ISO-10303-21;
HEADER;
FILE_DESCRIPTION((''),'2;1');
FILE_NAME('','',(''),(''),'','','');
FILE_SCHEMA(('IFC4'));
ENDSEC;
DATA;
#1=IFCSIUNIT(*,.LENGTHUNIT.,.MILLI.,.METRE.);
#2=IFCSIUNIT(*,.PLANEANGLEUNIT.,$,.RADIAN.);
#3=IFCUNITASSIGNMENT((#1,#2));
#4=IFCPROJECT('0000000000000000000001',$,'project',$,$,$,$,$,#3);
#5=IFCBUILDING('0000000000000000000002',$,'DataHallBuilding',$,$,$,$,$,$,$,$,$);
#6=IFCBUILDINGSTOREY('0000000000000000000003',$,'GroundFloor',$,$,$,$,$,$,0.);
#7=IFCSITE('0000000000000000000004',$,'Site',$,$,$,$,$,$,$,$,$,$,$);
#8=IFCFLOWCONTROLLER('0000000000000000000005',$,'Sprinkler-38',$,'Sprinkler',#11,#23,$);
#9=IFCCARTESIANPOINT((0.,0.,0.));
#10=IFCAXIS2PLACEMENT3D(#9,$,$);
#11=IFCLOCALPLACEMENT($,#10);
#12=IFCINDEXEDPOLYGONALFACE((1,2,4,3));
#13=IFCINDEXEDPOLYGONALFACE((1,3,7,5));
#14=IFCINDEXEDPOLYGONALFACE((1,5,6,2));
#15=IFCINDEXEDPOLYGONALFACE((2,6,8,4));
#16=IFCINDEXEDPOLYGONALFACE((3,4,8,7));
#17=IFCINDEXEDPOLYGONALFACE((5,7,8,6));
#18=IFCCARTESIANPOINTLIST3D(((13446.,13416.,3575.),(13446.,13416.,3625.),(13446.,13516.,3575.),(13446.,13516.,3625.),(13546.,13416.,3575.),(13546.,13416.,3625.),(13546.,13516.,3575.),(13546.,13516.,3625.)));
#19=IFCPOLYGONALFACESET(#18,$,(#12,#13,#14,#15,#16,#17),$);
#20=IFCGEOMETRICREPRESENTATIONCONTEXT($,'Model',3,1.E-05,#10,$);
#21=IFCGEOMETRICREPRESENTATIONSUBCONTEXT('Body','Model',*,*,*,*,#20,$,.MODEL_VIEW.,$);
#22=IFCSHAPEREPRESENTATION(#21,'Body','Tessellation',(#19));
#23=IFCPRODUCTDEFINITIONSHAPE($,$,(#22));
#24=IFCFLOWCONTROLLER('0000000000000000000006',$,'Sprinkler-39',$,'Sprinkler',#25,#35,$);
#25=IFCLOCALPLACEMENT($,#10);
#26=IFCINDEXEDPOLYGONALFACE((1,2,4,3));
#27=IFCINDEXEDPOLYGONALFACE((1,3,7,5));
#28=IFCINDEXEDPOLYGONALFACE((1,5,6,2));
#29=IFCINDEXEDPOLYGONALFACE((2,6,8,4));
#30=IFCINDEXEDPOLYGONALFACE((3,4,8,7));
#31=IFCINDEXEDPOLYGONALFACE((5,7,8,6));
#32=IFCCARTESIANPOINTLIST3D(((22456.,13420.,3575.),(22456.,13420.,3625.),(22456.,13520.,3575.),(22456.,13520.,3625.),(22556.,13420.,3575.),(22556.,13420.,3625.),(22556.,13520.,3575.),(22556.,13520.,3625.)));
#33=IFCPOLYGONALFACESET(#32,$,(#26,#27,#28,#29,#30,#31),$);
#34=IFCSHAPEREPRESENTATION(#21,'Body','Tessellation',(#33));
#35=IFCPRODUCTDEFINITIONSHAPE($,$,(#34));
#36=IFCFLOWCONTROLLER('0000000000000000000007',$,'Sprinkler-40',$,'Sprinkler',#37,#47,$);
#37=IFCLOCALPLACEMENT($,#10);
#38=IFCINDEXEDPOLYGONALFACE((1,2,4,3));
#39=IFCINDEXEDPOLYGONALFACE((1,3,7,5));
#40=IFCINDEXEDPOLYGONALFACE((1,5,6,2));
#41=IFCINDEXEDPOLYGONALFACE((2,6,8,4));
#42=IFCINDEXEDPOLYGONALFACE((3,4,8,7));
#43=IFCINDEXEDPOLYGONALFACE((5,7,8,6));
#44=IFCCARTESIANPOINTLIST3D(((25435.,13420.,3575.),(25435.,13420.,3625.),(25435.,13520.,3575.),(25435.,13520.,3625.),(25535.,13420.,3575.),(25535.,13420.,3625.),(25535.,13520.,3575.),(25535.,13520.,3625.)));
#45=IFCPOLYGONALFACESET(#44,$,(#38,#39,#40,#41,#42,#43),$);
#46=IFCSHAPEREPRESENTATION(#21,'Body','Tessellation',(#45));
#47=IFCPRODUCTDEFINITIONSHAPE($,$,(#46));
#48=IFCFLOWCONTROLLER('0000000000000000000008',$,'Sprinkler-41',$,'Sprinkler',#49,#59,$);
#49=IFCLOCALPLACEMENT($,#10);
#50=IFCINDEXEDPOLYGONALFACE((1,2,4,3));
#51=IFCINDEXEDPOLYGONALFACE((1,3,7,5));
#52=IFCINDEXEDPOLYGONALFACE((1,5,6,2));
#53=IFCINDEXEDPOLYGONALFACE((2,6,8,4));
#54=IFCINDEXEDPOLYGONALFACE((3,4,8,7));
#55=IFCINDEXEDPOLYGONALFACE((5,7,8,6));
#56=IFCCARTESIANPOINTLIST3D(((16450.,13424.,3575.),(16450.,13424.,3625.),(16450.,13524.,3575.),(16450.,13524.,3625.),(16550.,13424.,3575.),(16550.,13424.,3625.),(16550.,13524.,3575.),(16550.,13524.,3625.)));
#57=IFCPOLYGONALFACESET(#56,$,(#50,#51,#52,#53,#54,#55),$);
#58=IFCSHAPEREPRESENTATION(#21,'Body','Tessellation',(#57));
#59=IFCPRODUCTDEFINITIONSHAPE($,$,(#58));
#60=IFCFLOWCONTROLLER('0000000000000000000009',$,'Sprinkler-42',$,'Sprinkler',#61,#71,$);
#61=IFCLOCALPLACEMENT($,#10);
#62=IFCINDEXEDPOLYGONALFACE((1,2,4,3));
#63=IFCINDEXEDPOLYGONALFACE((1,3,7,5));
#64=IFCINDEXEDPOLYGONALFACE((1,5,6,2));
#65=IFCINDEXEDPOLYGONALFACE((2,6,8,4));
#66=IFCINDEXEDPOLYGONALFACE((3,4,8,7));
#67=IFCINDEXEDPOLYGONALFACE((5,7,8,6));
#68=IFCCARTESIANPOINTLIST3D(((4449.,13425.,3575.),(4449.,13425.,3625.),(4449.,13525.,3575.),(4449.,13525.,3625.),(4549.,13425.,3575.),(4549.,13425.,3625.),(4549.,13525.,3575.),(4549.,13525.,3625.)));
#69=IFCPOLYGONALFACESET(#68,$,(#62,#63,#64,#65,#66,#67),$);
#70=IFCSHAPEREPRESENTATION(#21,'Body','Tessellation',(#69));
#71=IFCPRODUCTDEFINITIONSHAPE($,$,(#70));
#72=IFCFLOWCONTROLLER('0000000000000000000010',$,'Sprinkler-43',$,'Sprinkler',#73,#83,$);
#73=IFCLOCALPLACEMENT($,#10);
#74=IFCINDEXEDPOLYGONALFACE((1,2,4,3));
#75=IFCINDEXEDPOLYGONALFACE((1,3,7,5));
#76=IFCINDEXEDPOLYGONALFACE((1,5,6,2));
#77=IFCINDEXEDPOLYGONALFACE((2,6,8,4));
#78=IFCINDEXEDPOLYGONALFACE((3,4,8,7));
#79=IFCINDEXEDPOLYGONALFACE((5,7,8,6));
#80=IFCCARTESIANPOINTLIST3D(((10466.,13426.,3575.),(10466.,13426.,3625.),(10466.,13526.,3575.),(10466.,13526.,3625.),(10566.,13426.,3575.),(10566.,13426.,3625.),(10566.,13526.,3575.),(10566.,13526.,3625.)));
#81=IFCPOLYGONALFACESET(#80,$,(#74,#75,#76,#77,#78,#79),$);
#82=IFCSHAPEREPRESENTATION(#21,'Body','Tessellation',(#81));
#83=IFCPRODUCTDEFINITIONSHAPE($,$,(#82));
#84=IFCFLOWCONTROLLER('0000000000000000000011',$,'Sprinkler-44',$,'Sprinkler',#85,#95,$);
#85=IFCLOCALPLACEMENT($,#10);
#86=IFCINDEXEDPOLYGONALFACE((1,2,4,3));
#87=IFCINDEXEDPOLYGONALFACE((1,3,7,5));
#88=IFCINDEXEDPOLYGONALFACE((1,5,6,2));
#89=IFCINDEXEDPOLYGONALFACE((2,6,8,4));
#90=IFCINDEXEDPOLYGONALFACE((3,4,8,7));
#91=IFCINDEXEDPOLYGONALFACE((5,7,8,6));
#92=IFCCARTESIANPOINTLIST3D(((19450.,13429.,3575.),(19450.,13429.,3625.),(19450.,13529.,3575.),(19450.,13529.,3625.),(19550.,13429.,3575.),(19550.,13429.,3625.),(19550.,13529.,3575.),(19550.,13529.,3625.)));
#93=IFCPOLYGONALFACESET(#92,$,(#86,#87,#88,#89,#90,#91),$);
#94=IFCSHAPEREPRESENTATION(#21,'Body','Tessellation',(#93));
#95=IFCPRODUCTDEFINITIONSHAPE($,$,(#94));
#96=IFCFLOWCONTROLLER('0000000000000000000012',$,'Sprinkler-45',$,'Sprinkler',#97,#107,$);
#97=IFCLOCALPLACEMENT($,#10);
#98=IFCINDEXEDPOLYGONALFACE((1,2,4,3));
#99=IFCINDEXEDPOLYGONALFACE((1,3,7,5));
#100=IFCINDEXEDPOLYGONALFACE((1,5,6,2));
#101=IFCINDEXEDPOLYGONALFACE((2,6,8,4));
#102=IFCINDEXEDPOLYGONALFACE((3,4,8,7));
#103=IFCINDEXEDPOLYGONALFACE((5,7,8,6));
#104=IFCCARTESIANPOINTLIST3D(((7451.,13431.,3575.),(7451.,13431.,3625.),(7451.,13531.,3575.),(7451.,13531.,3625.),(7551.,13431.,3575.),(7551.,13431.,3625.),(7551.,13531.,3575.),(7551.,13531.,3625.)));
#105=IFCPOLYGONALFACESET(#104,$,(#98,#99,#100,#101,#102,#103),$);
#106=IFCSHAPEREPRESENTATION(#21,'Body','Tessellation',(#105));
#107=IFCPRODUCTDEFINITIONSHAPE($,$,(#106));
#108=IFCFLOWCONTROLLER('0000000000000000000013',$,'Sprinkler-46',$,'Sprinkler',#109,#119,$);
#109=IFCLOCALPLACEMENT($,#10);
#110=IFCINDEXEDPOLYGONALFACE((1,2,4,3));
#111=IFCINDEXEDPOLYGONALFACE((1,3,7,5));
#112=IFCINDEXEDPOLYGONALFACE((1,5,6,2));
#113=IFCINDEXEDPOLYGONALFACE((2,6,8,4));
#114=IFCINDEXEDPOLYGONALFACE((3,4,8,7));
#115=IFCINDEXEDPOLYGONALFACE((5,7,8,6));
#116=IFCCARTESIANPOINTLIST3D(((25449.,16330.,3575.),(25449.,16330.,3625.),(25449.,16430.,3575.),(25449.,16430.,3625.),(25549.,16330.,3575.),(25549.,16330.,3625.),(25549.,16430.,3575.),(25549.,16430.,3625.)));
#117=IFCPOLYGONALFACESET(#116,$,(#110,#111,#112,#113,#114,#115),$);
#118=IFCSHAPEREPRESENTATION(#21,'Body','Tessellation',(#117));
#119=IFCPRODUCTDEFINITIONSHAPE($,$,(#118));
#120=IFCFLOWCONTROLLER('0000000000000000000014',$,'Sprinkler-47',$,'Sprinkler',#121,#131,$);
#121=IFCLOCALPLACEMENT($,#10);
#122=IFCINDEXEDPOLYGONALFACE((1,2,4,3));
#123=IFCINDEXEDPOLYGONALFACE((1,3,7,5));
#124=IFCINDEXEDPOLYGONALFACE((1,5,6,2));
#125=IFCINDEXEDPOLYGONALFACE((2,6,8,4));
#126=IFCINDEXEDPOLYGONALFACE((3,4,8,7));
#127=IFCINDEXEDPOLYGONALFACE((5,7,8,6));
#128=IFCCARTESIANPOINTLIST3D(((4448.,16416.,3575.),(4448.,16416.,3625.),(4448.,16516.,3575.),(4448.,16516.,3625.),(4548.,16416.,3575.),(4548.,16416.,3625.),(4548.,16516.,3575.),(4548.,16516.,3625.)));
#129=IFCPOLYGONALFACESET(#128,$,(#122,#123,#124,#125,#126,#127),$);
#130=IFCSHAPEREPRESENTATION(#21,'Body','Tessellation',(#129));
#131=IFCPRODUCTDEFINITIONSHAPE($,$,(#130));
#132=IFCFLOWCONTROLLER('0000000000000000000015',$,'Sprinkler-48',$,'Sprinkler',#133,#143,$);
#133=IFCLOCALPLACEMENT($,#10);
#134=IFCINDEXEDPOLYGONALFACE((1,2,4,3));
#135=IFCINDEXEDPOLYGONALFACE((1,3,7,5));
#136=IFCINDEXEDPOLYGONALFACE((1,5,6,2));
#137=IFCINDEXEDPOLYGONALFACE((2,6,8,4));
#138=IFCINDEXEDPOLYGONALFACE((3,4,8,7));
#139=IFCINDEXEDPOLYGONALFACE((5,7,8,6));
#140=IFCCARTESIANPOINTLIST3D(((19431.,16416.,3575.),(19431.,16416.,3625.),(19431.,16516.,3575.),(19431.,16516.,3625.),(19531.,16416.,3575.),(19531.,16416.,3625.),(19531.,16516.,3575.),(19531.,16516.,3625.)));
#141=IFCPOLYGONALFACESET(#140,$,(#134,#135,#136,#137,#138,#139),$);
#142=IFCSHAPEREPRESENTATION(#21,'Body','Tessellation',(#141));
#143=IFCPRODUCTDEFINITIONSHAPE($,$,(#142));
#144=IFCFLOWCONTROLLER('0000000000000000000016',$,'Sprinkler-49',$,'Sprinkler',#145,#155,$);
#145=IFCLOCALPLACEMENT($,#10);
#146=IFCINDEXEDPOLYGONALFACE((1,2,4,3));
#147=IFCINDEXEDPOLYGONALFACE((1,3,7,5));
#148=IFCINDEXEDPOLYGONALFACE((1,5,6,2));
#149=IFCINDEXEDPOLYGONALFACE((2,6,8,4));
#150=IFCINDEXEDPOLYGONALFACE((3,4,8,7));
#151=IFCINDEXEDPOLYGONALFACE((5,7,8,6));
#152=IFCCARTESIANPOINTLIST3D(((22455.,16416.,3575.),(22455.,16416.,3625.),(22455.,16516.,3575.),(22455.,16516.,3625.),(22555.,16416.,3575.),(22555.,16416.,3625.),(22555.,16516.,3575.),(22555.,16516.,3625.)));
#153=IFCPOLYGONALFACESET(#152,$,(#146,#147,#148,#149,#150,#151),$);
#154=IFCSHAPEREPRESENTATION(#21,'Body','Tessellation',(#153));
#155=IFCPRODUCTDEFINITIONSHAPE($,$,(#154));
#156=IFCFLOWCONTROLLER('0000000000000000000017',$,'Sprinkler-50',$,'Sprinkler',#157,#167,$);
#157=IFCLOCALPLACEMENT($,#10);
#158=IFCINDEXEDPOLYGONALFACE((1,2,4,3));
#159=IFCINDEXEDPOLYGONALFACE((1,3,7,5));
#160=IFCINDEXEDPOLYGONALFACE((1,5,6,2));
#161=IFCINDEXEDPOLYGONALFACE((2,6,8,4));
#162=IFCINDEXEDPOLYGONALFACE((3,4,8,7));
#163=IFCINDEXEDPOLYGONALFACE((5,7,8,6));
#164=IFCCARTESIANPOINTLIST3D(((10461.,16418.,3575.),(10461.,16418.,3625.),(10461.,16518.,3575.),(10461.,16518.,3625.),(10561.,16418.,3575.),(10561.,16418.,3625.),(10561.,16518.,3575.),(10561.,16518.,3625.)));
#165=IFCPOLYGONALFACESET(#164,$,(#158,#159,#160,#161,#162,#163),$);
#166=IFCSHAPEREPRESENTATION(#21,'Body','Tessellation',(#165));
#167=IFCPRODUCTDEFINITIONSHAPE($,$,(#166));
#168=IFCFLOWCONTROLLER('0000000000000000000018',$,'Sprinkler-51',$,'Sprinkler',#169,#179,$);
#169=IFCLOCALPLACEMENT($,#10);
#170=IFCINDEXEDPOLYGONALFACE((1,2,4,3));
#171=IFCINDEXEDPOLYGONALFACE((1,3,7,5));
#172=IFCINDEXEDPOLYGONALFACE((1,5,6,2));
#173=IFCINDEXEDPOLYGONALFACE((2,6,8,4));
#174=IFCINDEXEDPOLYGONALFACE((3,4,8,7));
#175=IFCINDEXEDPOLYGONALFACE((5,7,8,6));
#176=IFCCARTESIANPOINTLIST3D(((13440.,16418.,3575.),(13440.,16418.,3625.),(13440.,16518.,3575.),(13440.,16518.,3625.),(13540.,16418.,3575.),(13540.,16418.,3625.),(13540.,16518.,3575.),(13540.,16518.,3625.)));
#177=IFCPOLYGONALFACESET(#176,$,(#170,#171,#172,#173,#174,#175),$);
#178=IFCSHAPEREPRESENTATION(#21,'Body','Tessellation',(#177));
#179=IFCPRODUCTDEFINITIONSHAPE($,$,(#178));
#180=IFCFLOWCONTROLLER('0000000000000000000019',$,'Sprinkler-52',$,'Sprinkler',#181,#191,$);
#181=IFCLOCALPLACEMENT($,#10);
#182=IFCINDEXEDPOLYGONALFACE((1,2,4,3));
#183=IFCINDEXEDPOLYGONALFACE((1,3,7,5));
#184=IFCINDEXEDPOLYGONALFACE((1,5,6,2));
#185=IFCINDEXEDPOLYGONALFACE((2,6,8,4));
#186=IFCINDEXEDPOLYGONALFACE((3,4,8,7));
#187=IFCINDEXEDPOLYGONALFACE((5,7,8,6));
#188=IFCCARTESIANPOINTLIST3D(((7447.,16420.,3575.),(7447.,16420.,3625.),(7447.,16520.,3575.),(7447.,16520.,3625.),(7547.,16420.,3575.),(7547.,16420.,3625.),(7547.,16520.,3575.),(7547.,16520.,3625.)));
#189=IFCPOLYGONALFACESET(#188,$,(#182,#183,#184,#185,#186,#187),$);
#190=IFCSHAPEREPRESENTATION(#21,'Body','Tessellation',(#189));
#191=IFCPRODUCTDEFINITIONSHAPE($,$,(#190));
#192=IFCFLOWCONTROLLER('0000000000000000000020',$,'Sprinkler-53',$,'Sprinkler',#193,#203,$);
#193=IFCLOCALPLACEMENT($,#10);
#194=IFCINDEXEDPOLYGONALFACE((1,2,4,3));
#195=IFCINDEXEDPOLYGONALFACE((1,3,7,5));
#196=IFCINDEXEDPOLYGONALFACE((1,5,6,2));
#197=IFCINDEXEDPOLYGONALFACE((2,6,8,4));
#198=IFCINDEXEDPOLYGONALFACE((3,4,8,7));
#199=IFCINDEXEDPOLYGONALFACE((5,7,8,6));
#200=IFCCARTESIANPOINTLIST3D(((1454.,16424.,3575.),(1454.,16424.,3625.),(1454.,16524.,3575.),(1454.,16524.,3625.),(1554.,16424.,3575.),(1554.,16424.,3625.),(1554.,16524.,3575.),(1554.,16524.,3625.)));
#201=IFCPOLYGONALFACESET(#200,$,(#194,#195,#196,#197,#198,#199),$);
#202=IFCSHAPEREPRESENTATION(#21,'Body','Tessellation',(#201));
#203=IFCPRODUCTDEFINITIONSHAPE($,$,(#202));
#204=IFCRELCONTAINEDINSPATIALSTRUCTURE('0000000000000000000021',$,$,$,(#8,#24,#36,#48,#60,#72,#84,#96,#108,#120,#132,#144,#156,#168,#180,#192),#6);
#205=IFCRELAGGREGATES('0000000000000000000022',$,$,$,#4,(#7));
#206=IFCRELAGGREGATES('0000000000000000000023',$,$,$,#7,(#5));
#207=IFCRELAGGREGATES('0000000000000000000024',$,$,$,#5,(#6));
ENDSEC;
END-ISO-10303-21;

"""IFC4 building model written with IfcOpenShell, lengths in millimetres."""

from ifc_helpers import new_model, si_unit, frame, origin, place, context, subcontext, project, spatial, rectangle, extrude, element, save


model = new_model("IFC4")

# Units and contexts
model_context = context("Model", 3, precision=1e-05, world=origin())
body_context = subcontext(model_context, "Body", "Model", "MODEL_VIEW")
ifc_project = project(units=[si_unit("LENGTHUNIT", "METRE", prefix="MILLI"), si_unit("PLANEANGLEUNIT", "RADIAN")])

# Site, building, storey
site = spatial("IfcSite", under=ifc_project, Name="Site")
building = spatial("IfcBuilding", under=site, Name="DataHallBuilding")
storey = spatial("IfcBuildingStorey", under=building, Name="GroundFloor", Elevation=0.0)

# Flow controllers
flow_controller_1_placement = place(None, origin())
element("IfcFlowController", 1, at=flow_controller_1_placement, inside=storey, Name="Sprinkler-38", ObjectType="Sprinkler", context=body_context, shape_type="SweptSolid", body=[
    extrude(rectangle(XDim=100.0, YDim=100.0), frame((13496.0, 13466.0, 3575.0), z_axis=(0.0, 0.0, 1.0), x_axis=(1.0, 0.0, 0.0)), (0.0, 0.0, 1.0), 50.0),
])
flow_controller_2_placement = place(None, origin())
element("IfcFlowController", 2, at=flow_controller_2_placement, inside=storey, Name="Sprinkler-39", ObjectType="Sprinkler", context=body_context, shape_type="SweptSolid", body=[
    extrude(rectangle(XDim=100.0, YDim=100.0), frame((22506.0, 13470.0, 3575.0), z_axis=(0.0, 0.0, 1.0), x_axis=(1.0, 0.0, 0.0)), (0.0, 0.0, 1.0), 50.0),
])
flow_controller_3_placement = place(None, origin())
element("IfcFlowController", 3, at=flow_controller_3_placement, inside=storey, Name="Sprinkler-40", ObjectType="Sprinkler", context=body_context, shape_type="SweptSolid", body=[
    extrude(rectangle(XDim=100.0, YDim=100.0), frame((25485.0, 13470.0, 3575.0), z_axis=(0.0, 0.0, 1.0), x_axis=(1.0, 0.0, 0.0)), (0.0, 0.0, 1.0), 50.0),
])
flow_controller_4_placement = place(None, origin())
element("IfcFlowController", 4, at=flow_controller_4_placement, inside=storey, Name="Sprinkler-41", ObjectType="Sprinkler", context=body_context, shape_type="SweptSolid", body=[
    extrude(rectangle(XDim=100.0, YDim=100.0), frame((16500.0, 13474.0, 3575.0), z_axis=(0.0, 0.0, 1.0), x_axis=(1.0, 0.0, 0.0)), (0.0, 0.0, 1.0), 50.0),
])
flow_controller_5_placement = place(None, origin())
element("IfcFlowController", 5, at=flow_controller_5_placement, inside=storey, Name="Sprinkler-42", ObjectType="Sprinkler", context=body_context, shape_type="SweptSolid", body=[
    extrude(rectangle(XDim=100.0, YDim=100.0), frame((4499.0, 13475.0, 3575.0), z_axis=(0.0, 0.0, 1.0), x_axis=(1.0, 0.0, 0.0)), (0.0, 0.0, 1.0), 50.0),
])
flow_controller_6_placement = place(None, origin())
element("IfcFlowController", 6, at=flow_controller_6_placement, inside=storey, Name="Sprinkler-43", ObjectType="Sprinkler", context=body_context, shape_type="SweptSolid", body=[
    extrude(rectangle(XDim=100.0, YDim=100.0), frame((10516.0, 13476.0, 3575.0), z_axis=(0.0, 0.0, 1.0), x_axis=(1.0, 0.0, 0.0)), (0.0, 0.0, 1.0), 50.0),
])
flow_controller_7_placement = place(None, origin())
element("IfcFlowController", 7, at=flow_controller_7_placement, inside=storey, Name="Sprinkler-44", ObjectType="Sprinkler", context=body_context, shape_type="SweptSolid", body=[
    extrude(rectangle(XDim=100.0, YDim=100.0), frame((19500.0, 13479.0, 3575.0), z_axis=(0.0, 0.0, 1.0), x_axis=(1.0, 0.0, 0.0)), (0.0, 0.0, 1.0), 50.0),
])
flow_controller_8_placement = place(None, origin())
element("IfcFlowController", 8, at=flow_controller_8_placement, inside=storey, Name="Sprinkler-45", ObjectType="Sprinkler", context=body_context, shape_type="SweptSolid", body=[
    extrude(rectangle(XDim=100.0, YDim=100.0), frame((7501.0, 13481.0, 3575.0), z_axis=(0.0, 0.0, 1.0), x_axis=(1.0, 0.0, 0.0)), (0.0, 0.0, 1.0), 50.0),
])
flow_controller_9_placement = place(None, origin())
element("IfcFlowController", 9, at=flow_controller_9_placement, inside=storey, Name="Sprinkler-46", ObjectType="Sprinkler", context=body_context, shape_type="SweptSolid", body=[
    extrude(rectangle(XDim=100.0, YDim=100.0), frame((25499.0, 16380.0, 3575.0), z_axis=(0.0, 0.0, 1.0), x_axis=(1.0, 0.0, 0.0)), (0.0, 0.0, 1.0), 50.0),
])
flow_controller_10_placement = place(None, origin())
element("IfcFlowController", 10, at=flow_controller_10_placement, inside=storey, Name="Sprinkler-47", ObjectType="Sprinkler", context=body_context, shape_type="SweptSolid", body=[
    extrude(rectangle(XDim=100.0, YDim=100.0), frame((4498.0, 16466.0, 3575.0), z_axis=(0.0, 0.0, 1.0), x_axis=(1.0, 0.0, 0.0)), (0.0, 0.0, 1.0), 50.0),
])
flow_controller_11_placement = place(None, origin())
element("IfcFlowController", 11, at=flow_controller_11_placement, inside=storey, Name="Sprinkler-48", ObjectType="Sprinkler", context=body_context, shape_type="SweptSolid", body=[
    extrude(rectangle(XDim=100.0, YDim=100.0), frame((19481.0, 16466.0, 3575.0), z_axis=(0.0, 0.0, 1.0), x_axis=(1.0, 0.0, 0.0)), (0.0, 0.0, 1.0), 50.0),
])
flow_controller_12_placement = place(None, origin())
element("IfcFlowController", 12, at=flow_controller_12_placement, inside=storey, Name="Sprinkler-49", ObjectType="Sprinkler", context=body_context, shape_type="SweptSolid", body=[
    extrude(rectangle(XDim=100.0, YDim=100.0), frame((22505.0, 16466.0, 3575.0), z_axis=(0.0, 0.0, 1.0), x_axis=(1.0, 0.0, 0.0)), (0.0, 0.0, 1.0), 50.0),
])
flow_controller_13_placement = place(None, origin())
element("IfcFlowController", 13, at=flow_controller_13_placement, inside=storey, Name="Sprinkler-50", ObjectType="Sprinkler", context=body_context, shape_type="SweptSolid", body=[
    extrude(rectangle(XDim=100.0, YDim=100.0), frame((10511.0, 16468.0, 3575.0), z_axis=(0.0, 0.0, 1.0), x_axis=(1.0, 0.0, 0.0)), (0.0, 0.0, 1.0), 50.0),
])
flow_controller_14_placement = place(None, origin())
element("IfcFlowController", 14, at=flow_controller_14_placement, inside=storey, Name="Sprinkler-51", ObjectType="Sprinkler", context=body_context, shape_type="SweptSolid", body=[
    extrude(rectangle(XDim=100.0, YDim=100.0), frame((13490.0, 16468.0, 3575.0), z_axis=(0.0, 0.0, 1.0), x_axis=(1.0, 0.0, 0.0)), (0.0, 0.0, 1.0), 50.0),
])
flow_controller_15_placement = place(None, origin())
element("IfcFlowController", 15, at=flow_controller_15_placement, inside=storey, Name="Sprinkler-52", ObjectType="Sprinkler", context=body_context, shape_type="SweptSolid", body=[
    extrude(rectangle(XDim=100.0, YDim=100.0), frame((7497.0, 16470.0, 3575.0), z_axis=(0.0, 0.0, 1.0), x_axis=(1.0, 0.0, 0.0)), (0.0, 0.0, 1.0), 50.0),
])
flow_controller_16_placement = place(None, origin())
element("IfcFlowController", 16, at=flow_controller_16_placement, inside=storey, Name="Sprinkler-53", ObjectType="Sprinkler", context=body_context, shape_type="SweptSolid", body=[
    extrude(rectangle(XDim=100.0, YDim=100.0), frame((1504.0, 16474.0, 3575.0), z_axis=(0.0, 0.0, 1.0), x_axis=(1.0, 0.0, 0.0)), (0.0, 0.0, 1.0), 50.0),
])

save(model, "model.ifc")
